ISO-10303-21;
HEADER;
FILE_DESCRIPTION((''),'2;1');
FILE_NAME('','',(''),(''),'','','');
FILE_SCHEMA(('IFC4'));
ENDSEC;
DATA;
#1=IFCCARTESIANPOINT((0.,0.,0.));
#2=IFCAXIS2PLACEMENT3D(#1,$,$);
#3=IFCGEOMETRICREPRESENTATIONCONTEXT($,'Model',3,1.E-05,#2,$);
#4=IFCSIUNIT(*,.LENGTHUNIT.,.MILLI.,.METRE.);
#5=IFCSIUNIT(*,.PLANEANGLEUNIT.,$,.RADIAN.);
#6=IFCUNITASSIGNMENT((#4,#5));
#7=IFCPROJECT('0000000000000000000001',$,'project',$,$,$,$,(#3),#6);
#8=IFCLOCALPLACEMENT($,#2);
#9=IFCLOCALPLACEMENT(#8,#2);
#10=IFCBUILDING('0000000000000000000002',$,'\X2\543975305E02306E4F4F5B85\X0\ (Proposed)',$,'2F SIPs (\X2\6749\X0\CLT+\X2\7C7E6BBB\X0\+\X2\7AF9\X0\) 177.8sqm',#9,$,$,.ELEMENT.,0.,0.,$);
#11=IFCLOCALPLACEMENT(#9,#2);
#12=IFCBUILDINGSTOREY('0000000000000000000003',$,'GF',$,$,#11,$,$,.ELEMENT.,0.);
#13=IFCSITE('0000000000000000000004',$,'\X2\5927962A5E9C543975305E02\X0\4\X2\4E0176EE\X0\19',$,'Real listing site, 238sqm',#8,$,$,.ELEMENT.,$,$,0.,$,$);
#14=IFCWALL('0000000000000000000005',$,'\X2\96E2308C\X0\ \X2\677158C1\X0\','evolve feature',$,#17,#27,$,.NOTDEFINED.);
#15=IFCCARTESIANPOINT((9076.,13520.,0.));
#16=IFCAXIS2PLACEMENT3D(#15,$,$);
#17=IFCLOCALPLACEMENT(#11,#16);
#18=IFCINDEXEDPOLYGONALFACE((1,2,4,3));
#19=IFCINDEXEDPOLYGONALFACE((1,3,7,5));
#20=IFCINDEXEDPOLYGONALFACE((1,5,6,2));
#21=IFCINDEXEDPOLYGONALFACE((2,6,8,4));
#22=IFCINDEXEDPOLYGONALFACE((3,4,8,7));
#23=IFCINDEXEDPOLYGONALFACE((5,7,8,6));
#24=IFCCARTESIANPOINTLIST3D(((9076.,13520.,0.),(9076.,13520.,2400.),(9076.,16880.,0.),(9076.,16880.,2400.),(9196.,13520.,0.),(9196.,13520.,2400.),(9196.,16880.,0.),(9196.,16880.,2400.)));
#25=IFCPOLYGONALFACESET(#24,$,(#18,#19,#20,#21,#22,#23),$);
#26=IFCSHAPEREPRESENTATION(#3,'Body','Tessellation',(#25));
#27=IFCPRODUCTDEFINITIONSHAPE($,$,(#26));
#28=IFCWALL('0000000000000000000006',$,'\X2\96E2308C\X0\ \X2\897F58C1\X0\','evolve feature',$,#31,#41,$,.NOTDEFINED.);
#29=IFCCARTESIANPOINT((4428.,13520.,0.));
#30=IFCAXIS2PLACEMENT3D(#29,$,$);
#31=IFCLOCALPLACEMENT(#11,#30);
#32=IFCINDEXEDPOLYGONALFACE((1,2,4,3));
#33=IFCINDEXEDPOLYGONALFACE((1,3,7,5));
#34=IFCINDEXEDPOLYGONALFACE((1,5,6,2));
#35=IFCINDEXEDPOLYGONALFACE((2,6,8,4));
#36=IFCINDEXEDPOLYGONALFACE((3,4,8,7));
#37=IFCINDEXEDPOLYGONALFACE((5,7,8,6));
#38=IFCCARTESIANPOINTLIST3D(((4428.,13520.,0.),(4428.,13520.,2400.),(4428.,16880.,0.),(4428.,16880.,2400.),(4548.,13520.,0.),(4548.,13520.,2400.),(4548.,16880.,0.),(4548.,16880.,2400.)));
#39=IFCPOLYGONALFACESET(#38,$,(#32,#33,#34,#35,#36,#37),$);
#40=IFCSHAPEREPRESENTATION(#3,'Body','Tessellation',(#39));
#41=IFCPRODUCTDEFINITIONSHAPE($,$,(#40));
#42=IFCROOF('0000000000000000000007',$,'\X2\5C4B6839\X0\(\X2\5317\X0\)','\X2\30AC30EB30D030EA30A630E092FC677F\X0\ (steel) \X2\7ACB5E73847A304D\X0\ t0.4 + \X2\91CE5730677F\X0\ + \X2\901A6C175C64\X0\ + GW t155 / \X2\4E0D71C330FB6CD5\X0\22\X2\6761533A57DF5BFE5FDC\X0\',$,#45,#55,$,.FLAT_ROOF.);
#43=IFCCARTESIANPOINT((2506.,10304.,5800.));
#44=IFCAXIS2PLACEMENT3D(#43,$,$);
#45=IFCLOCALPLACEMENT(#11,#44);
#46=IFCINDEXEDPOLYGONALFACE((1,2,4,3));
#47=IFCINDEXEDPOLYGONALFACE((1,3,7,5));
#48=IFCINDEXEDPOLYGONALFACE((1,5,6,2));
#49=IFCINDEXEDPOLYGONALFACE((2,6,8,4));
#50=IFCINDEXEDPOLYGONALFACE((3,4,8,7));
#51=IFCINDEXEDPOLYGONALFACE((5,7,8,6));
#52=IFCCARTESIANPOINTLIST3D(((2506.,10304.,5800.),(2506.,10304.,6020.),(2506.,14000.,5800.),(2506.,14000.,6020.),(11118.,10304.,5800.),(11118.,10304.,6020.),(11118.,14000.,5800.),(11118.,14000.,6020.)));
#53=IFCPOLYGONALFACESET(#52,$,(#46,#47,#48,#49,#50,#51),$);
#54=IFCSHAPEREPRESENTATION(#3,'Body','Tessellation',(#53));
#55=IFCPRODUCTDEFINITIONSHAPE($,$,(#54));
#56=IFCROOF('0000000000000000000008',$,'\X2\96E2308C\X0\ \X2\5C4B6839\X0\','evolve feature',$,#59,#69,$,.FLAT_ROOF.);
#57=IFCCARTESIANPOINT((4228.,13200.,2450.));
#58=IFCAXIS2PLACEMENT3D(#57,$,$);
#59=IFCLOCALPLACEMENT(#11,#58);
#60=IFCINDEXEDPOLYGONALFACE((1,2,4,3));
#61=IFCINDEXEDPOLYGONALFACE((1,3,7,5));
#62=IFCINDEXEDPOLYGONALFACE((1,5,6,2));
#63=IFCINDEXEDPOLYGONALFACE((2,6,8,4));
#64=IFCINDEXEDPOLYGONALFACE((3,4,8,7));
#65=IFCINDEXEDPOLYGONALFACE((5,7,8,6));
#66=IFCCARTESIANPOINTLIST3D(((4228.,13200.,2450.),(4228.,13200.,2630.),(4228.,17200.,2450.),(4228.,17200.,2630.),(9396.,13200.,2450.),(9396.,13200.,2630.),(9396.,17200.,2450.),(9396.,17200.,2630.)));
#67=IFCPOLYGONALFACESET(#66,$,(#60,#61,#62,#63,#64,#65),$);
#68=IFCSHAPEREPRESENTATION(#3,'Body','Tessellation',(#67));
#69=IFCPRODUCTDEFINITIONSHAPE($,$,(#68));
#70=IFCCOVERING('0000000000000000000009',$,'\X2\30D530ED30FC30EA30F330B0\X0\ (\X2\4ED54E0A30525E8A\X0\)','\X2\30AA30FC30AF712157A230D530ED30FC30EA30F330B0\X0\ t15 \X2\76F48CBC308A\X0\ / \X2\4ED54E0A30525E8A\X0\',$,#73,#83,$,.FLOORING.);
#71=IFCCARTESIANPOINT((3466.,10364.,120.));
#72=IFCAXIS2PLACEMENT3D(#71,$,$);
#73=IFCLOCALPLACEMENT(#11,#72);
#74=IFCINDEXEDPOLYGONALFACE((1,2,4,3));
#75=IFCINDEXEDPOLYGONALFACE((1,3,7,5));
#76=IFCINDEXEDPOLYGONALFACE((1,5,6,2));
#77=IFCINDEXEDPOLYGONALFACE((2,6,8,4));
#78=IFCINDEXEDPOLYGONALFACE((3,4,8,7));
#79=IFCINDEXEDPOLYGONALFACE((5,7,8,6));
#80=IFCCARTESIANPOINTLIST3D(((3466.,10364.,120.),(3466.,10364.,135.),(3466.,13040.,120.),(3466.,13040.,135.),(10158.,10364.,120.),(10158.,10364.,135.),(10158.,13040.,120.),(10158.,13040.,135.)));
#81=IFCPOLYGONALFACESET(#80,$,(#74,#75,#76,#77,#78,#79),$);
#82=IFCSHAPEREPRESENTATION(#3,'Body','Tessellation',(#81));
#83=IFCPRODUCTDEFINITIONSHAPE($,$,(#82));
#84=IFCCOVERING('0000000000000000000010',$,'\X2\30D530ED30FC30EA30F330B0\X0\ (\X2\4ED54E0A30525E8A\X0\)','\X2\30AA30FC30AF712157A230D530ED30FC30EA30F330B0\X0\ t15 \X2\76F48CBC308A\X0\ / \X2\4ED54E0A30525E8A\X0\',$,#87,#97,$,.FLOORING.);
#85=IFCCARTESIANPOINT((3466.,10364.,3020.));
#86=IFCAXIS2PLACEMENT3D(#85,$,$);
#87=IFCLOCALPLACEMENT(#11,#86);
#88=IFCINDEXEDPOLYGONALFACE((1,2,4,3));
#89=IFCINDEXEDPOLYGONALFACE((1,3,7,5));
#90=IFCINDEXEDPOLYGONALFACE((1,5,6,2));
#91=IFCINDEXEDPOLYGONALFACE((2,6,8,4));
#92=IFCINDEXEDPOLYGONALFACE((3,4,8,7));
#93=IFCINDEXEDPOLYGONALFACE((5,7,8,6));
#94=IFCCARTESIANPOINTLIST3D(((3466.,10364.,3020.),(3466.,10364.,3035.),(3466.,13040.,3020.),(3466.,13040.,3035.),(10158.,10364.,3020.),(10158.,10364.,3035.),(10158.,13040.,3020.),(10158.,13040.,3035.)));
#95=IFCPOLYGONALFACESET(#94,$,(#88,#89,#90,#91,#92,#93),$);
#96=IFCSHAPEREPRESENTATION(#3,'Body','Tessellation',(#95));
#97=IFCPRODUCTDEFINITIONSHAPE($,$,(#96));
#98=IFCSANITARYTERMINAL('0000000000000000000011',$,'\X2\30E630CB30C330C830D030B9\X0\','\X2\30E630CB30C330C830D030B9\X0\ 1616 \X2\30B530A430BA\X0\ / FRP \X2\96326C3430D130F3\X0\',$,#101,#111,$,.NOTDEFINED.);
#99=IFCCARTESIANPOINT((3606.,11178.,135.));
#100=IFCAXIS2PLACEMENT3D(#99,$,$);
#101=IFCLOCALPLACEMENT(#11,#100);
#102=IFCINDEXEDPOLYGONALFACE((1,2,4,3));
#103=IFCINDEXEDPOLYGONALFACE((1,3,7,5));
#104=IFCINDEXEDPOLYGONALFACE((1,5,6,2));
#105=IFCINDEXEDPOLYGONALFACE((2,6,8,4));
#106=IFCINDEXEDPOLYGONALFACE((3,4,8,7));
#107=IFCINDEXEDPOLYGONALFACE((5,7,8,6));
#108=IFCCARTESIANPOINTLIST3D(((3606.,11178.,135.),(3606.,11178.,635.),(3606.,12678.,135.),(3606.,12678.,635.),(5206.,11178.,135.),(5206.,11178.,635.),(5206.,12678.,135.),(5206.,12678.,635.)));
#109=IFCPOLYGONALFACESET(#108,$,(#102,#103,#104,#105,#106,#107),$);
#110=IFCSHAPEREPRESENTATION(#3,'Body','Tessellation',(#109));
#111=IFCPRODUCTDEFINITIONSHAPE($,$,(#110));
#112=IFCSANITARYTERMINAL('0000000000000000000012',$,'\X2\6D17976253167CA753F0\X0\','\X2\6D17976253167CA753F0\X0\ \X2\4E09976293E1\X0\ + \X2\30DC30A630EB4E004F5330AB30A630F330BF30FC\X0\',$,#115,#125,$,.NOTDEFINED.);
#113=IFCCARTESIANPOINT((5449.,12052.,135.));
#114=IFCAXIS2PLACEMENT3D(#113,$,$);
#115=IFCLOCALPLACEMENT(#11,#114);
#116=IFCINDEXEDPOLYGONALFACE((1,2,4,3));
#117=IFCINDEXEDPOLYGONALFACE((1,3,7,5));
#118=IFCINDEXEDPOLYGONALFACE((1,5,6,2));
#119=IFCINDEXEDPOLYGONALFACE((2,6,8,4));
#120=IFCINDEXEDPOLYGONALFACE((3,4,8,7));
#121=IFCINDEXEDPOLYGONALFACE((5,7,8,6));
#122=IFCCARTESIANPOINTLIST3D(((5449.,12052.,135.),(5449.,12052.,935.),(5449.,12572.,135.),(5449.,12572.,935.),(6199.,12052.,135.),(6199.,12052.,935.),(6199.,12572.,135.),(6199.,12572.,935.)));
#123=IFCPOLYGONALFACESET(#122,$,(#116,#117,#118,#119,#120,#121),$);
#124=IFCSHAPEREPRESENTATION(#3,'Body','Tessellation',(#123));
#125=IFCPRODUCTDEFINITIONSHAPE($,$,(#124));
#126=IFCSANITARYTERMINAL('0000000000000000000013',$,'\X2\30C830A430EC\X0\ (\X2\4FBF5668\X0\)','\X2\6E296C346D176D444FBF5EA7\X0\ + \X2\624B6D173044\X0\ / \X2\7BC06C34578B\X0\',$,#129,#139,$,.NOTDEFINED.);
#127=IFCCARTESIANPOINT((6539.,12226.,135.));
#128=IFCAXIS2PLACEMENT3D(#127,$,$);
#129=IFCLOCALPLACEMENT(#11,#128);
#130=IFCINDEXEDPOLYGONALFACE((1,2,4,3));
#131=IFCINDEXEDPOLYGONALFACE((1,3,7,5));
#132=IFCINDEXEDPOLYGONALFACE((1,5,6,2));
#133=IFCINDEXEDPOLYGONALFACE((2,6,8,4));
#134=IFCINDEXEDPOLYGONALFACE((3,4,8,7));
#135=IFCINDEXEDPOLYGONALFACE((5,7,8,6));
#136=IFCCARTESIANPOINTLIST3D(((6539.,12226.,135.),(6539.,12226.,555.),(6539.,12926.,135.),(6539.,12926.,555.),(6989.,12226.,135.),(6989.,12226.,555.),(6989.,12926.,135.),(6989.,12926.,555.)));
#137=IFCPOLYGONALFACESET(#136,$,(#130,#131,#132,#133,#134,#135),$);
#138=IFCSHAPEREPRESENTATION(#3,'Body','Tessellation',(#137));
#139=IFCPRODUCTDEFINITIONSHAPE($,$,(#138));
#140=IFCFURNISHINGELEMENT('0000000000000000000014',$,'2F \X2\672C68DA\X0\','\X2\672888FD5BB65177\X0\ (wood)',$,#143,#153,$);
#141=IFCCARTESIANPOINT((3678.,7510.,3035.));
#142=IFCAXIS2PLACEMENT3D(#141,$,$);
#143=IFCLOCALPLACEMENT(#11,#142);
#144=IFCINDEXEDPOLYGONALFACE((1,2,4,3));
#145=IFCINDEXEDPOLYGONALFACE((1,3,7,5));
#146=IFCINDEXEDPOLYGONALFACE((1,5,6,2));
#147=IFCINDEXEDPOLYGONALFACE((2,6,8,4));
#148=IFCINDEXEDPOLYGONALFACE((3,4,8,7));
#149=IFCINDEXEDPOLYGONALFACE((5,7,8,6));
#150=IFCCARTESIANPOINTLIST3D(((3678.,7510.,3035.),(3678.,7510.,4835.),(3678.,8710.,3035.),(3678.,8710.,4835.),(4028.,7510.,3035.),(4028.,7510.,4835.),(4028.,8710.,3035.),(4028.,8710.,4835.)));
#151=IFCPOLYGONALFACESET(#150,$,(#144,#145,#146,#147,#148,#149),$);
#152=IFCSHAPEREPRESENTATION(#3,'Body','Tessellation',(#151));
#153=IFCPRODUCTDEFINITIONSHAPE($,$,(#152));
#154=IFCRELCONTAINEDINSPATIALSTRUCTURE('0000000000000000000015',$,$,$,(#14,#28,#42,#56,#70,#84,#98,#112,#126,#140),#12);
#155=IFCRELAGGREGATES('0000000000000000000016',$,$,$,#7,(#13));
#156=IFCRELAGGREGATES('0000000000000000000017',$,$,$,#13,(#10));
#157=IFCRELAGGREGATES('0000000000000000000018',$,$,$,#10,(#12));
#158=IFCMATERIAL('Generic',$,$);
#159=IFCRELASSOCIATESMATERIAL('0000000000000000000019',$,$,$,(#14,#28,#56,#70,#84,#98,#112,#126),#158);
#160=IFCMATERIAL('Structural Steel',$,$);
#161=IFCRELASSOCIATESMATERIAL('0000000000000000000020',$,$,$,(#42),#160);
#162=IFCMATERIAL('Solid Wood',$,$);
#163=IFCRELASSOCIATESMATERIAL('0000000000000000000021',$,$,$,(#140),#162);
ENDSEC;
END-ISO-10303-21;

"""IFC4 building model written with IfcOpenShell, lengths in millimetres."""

from ifc_helpers import new_model, si_unit, frame, frame_2d, origin, place, context, project, spatial, rectangle, extrude, material, element, save


model = new_model("IFC4")

# Units and contexts
model_context = context("Model", 3, precision=1e-05, world=origin())
ifc_project = project(units=[si_unit("LENGTHUNIT", "METRE", prefix="MILLI"), si_unit("PLANEANGLEUNIT", "RADIAN")], contexts=[model_context])

# Site, building, storey
site_placement = place(None, origin())
site = spatial("IfcSite", under=ifc_project, at=site_placement, Name="大阪府吹田市4丁目19", ObjectType="Real listing site, 238sqm", CompositionType="ELEMENT", RefElevation=0.0)
building_placement = place(site_placement, origin())
building = spatial("IfcBuilding", under=site, at=building_placement, Name="吹田市の住宅 (Proposed)", ObjectType="2F SIPs (杉CLT+籾殻+竹) 177.8sqm", CompositionType="ELEMENT", ElevationOfRefHeight=0.0, ElevationOfTerrain=0.0)
storey_placement = place(building_placement, origin())
storey = spatial("IfcBuildingStorey", under=building, at=storey_placement, Name="GF", CompositionType="ELEMENT", Elevation=0.0)

# Shared definitions
ifc_material_1 = material(Name="Solid Wood")
ifc_material_2 = material(Name="Generic")

# Walls
wall_1_placement = place(storey_placement, frame((9076.0, 13520.0, 0.0)))
element("IfcWall", 1, at=wall_1_placement, inside=storey, material=ifc_material_2, Name="離れ 東壁", Description="evolve feature", PredefinedType="NOTDEFINED", context=model_context, shape_type="SweptSolid", body=[
    extrude(rectangle(XDim=120.0, YDim=3360.0, at=frame_2d((60.0, 1680.0))), frame((9076.0, 13520.0, 0.0)), (0.0, 0.0, 1.0), 2400.0),
])
wall_2_placement = place(storey_placement, frame((4428.0, 13520.0, 0.0)))
element("IfcWall", 2, at=wall_2_placement, inside=storey, material=ifc_material_2, Name="離れ 西壁", Description="evolve feature", PredefinedType="NOTDEFINED", context=model_context, shape_type="SweptSolid", body=[
    extrude(rectangle(XDim=120.0, YDim=3360.0, at=frame_2d((60.0, 1680.0))), frame((4428.0, 13520.0, 0.0)), (0.0, 0.0, 1.0), 2400.0),
])

# Roofs
ifc_material_3 = material(Name="Structural Steel")
for number, where, name in (
    (3, (2506.0, 10304.0, 5800.0), "屋根(北)"),
):
    element("IfcRoof", number, at=place(storey_placement, frame(where)), inside=storey, material=ifc_material_3, Name=name, Description="ガルバリウム鋼板 (steel) 立平葺き t0.4 + 野地板 + 通気層 + GW t155 / 不燃・法22条区域対応", PredefinedType="FLAT_ROOF", context=model_context, shape_type="SweptSolid", body=[
        extrude(rectangle(XDim=8612.0, YDim=3696.0, at=frame_2d((4306.0, 1848.0))), frame((2506.0, 10304.0, 5800.0)), (0.0, 0.0, 1.0), 220.0),
    ])
roof_1_placement = place(storey_placement, frame((4228.0, 13200.0, 2450.0)))
element("IfcRoof", 4, at=roof_1_placement, inside=storey, material=ifc_material_2, Name="離れ 屋根", Description="evolve feature", PredefinedType="FLAT_ROOF", context=model_context, shape_type="SweptSolid", body=[
    extrude(rectangle(XDim=5168.0, YDim=4000.0, at=frame_2d((2584.0, 2000.0))), frame((4228.0, 13200.0, 2450.0)), (0.0, 0.0, 1.0), 180.0),
])

# Coverings
covering_1_placement = place(storey_placement, frame((3466.0, 10364.0, 120.0)))
element("IfcCovering", 5, at=covering_1_placement, inside=storey, material=ifc_material_2, Name="フローリング (仕上げ床)", Description="オーク無垢フローリング t15 直貼り / 仕上げ床", PredefinedType="FLOORING", context=model_context, shape_type="SweptSolid", body=[
    extrude(rectangle(XDim=6692.0, YDim=2676.0, at=frame_2d((3346.0, 1338.0))), frame((3466.0, 10364.0, 120.0)), (0.0, 0.0, 1.0), 15.0),
])
covering_2_placement = place(storey_placement, frame((3466.0, 10364.0, 3020.0)))
element("IfcCovering", 6, at=covering_2_placement, inside=storey, material=ifc_material_2, Name="フローリング (仕上げ床)", Description="オーク無垢フローリング t15 直貼り / 仕上げ床", PredefinedType="FLOORING", context=model_context, shape_type="SweptSolid", body=[
    extrude(rectangle(XDim=6692.0, YDim=2676.0, at=frame_2d((3346.0, 1338.0))), frame((3466.0, 10364.0, 3020.0)), (0.0, 0.0, 1.0), 15.0),
])

# Sanitary terminals
sanitary_terminal_1_placement = place(storey_placement, frame((3606.0, 11178.0, 135.0)))
element("IfcSanitaryTerminal", 7, at=sanitary_terminal_1_placement, inside=storey, material=ifc_material_2, Name="ユニットバス", Description="ユニットバス 1616 サイズ / FRP 防水パン", PredefinedType="NOTDEFINED", context=model_context, shape_type="SweptSolid", body=[
    extrude(rectangle(XDim=1600.0, YDim=1500.0, at=frame_2d((800.0, 750.0))), frame((3606.0, 11178.0, 135.0)), (0.0, 0.0, 1.0), 500.0),
])
sanitary_terminal_2_placement = place(storey_placement, frame((5449.0, 12052.0, 135.0)))
element("IfcSanitaryTerminal", 8, at=sanitary_terminal_2_placement, inside=storey, material=ifc_material_2, Name="洗面化粧台", Description="洗面化粧台 三面鏡 + ボウル一体カウンター", PredefinedType="NOTDEFINED", context=model_context, shape_type="SweptSolid", body=[
    extrude(rectangle(XDim=750.0, YDim=520.0, at=frame_2d((375.0, 260.0))), frame((5449.0, 12052.0, 135.0)), (0.0, 0.0, 1.0), 800.0),
])
sanitary_terminal_3_placement = place(storey_placement, frame((6539.0, 12226.0, 135.0)))
element("IfcSanitaryTerminal", 9, at=sanitary_terminal_3_placement, inside=storey, material=ifc_material_2, Name="トイレ (便器)", Description="温水洗浄便座 + 手洗い / 節水型", PredefinedType="NOTDEFINED", context=model_context, shape_type="SweptSolid", body=[
    extrude(rectangle(XDim=450.0, YDim=700.0, at=frame_2d((225.0, 350.0))), frame((6539.0, 12226.0, 135.0)), (0.0, 0.0, 1.0), 420.0),
])

# Furnishing element
furnishing_placement = place(storey_placement, frame((3678.0, 7510.0, 3035.0)))
element("IfcFurnishingElement", 10, at=furnishing_placement, inside=storey, material=ifc_material_1, Name="2F 本棚", Description="木製家具 (wood)", context=model_context, shape_type="SweptSolid", body=[
    extrude(rectangle(XDim=350.0, YDim=1200.0, at=frame_2d((175.0, 600.0))), frame((3678.0, 7510.0, 3035.0)), (0.0, 0.0, 1.0), 1800.0),
])

save(model, "model.ifc")
